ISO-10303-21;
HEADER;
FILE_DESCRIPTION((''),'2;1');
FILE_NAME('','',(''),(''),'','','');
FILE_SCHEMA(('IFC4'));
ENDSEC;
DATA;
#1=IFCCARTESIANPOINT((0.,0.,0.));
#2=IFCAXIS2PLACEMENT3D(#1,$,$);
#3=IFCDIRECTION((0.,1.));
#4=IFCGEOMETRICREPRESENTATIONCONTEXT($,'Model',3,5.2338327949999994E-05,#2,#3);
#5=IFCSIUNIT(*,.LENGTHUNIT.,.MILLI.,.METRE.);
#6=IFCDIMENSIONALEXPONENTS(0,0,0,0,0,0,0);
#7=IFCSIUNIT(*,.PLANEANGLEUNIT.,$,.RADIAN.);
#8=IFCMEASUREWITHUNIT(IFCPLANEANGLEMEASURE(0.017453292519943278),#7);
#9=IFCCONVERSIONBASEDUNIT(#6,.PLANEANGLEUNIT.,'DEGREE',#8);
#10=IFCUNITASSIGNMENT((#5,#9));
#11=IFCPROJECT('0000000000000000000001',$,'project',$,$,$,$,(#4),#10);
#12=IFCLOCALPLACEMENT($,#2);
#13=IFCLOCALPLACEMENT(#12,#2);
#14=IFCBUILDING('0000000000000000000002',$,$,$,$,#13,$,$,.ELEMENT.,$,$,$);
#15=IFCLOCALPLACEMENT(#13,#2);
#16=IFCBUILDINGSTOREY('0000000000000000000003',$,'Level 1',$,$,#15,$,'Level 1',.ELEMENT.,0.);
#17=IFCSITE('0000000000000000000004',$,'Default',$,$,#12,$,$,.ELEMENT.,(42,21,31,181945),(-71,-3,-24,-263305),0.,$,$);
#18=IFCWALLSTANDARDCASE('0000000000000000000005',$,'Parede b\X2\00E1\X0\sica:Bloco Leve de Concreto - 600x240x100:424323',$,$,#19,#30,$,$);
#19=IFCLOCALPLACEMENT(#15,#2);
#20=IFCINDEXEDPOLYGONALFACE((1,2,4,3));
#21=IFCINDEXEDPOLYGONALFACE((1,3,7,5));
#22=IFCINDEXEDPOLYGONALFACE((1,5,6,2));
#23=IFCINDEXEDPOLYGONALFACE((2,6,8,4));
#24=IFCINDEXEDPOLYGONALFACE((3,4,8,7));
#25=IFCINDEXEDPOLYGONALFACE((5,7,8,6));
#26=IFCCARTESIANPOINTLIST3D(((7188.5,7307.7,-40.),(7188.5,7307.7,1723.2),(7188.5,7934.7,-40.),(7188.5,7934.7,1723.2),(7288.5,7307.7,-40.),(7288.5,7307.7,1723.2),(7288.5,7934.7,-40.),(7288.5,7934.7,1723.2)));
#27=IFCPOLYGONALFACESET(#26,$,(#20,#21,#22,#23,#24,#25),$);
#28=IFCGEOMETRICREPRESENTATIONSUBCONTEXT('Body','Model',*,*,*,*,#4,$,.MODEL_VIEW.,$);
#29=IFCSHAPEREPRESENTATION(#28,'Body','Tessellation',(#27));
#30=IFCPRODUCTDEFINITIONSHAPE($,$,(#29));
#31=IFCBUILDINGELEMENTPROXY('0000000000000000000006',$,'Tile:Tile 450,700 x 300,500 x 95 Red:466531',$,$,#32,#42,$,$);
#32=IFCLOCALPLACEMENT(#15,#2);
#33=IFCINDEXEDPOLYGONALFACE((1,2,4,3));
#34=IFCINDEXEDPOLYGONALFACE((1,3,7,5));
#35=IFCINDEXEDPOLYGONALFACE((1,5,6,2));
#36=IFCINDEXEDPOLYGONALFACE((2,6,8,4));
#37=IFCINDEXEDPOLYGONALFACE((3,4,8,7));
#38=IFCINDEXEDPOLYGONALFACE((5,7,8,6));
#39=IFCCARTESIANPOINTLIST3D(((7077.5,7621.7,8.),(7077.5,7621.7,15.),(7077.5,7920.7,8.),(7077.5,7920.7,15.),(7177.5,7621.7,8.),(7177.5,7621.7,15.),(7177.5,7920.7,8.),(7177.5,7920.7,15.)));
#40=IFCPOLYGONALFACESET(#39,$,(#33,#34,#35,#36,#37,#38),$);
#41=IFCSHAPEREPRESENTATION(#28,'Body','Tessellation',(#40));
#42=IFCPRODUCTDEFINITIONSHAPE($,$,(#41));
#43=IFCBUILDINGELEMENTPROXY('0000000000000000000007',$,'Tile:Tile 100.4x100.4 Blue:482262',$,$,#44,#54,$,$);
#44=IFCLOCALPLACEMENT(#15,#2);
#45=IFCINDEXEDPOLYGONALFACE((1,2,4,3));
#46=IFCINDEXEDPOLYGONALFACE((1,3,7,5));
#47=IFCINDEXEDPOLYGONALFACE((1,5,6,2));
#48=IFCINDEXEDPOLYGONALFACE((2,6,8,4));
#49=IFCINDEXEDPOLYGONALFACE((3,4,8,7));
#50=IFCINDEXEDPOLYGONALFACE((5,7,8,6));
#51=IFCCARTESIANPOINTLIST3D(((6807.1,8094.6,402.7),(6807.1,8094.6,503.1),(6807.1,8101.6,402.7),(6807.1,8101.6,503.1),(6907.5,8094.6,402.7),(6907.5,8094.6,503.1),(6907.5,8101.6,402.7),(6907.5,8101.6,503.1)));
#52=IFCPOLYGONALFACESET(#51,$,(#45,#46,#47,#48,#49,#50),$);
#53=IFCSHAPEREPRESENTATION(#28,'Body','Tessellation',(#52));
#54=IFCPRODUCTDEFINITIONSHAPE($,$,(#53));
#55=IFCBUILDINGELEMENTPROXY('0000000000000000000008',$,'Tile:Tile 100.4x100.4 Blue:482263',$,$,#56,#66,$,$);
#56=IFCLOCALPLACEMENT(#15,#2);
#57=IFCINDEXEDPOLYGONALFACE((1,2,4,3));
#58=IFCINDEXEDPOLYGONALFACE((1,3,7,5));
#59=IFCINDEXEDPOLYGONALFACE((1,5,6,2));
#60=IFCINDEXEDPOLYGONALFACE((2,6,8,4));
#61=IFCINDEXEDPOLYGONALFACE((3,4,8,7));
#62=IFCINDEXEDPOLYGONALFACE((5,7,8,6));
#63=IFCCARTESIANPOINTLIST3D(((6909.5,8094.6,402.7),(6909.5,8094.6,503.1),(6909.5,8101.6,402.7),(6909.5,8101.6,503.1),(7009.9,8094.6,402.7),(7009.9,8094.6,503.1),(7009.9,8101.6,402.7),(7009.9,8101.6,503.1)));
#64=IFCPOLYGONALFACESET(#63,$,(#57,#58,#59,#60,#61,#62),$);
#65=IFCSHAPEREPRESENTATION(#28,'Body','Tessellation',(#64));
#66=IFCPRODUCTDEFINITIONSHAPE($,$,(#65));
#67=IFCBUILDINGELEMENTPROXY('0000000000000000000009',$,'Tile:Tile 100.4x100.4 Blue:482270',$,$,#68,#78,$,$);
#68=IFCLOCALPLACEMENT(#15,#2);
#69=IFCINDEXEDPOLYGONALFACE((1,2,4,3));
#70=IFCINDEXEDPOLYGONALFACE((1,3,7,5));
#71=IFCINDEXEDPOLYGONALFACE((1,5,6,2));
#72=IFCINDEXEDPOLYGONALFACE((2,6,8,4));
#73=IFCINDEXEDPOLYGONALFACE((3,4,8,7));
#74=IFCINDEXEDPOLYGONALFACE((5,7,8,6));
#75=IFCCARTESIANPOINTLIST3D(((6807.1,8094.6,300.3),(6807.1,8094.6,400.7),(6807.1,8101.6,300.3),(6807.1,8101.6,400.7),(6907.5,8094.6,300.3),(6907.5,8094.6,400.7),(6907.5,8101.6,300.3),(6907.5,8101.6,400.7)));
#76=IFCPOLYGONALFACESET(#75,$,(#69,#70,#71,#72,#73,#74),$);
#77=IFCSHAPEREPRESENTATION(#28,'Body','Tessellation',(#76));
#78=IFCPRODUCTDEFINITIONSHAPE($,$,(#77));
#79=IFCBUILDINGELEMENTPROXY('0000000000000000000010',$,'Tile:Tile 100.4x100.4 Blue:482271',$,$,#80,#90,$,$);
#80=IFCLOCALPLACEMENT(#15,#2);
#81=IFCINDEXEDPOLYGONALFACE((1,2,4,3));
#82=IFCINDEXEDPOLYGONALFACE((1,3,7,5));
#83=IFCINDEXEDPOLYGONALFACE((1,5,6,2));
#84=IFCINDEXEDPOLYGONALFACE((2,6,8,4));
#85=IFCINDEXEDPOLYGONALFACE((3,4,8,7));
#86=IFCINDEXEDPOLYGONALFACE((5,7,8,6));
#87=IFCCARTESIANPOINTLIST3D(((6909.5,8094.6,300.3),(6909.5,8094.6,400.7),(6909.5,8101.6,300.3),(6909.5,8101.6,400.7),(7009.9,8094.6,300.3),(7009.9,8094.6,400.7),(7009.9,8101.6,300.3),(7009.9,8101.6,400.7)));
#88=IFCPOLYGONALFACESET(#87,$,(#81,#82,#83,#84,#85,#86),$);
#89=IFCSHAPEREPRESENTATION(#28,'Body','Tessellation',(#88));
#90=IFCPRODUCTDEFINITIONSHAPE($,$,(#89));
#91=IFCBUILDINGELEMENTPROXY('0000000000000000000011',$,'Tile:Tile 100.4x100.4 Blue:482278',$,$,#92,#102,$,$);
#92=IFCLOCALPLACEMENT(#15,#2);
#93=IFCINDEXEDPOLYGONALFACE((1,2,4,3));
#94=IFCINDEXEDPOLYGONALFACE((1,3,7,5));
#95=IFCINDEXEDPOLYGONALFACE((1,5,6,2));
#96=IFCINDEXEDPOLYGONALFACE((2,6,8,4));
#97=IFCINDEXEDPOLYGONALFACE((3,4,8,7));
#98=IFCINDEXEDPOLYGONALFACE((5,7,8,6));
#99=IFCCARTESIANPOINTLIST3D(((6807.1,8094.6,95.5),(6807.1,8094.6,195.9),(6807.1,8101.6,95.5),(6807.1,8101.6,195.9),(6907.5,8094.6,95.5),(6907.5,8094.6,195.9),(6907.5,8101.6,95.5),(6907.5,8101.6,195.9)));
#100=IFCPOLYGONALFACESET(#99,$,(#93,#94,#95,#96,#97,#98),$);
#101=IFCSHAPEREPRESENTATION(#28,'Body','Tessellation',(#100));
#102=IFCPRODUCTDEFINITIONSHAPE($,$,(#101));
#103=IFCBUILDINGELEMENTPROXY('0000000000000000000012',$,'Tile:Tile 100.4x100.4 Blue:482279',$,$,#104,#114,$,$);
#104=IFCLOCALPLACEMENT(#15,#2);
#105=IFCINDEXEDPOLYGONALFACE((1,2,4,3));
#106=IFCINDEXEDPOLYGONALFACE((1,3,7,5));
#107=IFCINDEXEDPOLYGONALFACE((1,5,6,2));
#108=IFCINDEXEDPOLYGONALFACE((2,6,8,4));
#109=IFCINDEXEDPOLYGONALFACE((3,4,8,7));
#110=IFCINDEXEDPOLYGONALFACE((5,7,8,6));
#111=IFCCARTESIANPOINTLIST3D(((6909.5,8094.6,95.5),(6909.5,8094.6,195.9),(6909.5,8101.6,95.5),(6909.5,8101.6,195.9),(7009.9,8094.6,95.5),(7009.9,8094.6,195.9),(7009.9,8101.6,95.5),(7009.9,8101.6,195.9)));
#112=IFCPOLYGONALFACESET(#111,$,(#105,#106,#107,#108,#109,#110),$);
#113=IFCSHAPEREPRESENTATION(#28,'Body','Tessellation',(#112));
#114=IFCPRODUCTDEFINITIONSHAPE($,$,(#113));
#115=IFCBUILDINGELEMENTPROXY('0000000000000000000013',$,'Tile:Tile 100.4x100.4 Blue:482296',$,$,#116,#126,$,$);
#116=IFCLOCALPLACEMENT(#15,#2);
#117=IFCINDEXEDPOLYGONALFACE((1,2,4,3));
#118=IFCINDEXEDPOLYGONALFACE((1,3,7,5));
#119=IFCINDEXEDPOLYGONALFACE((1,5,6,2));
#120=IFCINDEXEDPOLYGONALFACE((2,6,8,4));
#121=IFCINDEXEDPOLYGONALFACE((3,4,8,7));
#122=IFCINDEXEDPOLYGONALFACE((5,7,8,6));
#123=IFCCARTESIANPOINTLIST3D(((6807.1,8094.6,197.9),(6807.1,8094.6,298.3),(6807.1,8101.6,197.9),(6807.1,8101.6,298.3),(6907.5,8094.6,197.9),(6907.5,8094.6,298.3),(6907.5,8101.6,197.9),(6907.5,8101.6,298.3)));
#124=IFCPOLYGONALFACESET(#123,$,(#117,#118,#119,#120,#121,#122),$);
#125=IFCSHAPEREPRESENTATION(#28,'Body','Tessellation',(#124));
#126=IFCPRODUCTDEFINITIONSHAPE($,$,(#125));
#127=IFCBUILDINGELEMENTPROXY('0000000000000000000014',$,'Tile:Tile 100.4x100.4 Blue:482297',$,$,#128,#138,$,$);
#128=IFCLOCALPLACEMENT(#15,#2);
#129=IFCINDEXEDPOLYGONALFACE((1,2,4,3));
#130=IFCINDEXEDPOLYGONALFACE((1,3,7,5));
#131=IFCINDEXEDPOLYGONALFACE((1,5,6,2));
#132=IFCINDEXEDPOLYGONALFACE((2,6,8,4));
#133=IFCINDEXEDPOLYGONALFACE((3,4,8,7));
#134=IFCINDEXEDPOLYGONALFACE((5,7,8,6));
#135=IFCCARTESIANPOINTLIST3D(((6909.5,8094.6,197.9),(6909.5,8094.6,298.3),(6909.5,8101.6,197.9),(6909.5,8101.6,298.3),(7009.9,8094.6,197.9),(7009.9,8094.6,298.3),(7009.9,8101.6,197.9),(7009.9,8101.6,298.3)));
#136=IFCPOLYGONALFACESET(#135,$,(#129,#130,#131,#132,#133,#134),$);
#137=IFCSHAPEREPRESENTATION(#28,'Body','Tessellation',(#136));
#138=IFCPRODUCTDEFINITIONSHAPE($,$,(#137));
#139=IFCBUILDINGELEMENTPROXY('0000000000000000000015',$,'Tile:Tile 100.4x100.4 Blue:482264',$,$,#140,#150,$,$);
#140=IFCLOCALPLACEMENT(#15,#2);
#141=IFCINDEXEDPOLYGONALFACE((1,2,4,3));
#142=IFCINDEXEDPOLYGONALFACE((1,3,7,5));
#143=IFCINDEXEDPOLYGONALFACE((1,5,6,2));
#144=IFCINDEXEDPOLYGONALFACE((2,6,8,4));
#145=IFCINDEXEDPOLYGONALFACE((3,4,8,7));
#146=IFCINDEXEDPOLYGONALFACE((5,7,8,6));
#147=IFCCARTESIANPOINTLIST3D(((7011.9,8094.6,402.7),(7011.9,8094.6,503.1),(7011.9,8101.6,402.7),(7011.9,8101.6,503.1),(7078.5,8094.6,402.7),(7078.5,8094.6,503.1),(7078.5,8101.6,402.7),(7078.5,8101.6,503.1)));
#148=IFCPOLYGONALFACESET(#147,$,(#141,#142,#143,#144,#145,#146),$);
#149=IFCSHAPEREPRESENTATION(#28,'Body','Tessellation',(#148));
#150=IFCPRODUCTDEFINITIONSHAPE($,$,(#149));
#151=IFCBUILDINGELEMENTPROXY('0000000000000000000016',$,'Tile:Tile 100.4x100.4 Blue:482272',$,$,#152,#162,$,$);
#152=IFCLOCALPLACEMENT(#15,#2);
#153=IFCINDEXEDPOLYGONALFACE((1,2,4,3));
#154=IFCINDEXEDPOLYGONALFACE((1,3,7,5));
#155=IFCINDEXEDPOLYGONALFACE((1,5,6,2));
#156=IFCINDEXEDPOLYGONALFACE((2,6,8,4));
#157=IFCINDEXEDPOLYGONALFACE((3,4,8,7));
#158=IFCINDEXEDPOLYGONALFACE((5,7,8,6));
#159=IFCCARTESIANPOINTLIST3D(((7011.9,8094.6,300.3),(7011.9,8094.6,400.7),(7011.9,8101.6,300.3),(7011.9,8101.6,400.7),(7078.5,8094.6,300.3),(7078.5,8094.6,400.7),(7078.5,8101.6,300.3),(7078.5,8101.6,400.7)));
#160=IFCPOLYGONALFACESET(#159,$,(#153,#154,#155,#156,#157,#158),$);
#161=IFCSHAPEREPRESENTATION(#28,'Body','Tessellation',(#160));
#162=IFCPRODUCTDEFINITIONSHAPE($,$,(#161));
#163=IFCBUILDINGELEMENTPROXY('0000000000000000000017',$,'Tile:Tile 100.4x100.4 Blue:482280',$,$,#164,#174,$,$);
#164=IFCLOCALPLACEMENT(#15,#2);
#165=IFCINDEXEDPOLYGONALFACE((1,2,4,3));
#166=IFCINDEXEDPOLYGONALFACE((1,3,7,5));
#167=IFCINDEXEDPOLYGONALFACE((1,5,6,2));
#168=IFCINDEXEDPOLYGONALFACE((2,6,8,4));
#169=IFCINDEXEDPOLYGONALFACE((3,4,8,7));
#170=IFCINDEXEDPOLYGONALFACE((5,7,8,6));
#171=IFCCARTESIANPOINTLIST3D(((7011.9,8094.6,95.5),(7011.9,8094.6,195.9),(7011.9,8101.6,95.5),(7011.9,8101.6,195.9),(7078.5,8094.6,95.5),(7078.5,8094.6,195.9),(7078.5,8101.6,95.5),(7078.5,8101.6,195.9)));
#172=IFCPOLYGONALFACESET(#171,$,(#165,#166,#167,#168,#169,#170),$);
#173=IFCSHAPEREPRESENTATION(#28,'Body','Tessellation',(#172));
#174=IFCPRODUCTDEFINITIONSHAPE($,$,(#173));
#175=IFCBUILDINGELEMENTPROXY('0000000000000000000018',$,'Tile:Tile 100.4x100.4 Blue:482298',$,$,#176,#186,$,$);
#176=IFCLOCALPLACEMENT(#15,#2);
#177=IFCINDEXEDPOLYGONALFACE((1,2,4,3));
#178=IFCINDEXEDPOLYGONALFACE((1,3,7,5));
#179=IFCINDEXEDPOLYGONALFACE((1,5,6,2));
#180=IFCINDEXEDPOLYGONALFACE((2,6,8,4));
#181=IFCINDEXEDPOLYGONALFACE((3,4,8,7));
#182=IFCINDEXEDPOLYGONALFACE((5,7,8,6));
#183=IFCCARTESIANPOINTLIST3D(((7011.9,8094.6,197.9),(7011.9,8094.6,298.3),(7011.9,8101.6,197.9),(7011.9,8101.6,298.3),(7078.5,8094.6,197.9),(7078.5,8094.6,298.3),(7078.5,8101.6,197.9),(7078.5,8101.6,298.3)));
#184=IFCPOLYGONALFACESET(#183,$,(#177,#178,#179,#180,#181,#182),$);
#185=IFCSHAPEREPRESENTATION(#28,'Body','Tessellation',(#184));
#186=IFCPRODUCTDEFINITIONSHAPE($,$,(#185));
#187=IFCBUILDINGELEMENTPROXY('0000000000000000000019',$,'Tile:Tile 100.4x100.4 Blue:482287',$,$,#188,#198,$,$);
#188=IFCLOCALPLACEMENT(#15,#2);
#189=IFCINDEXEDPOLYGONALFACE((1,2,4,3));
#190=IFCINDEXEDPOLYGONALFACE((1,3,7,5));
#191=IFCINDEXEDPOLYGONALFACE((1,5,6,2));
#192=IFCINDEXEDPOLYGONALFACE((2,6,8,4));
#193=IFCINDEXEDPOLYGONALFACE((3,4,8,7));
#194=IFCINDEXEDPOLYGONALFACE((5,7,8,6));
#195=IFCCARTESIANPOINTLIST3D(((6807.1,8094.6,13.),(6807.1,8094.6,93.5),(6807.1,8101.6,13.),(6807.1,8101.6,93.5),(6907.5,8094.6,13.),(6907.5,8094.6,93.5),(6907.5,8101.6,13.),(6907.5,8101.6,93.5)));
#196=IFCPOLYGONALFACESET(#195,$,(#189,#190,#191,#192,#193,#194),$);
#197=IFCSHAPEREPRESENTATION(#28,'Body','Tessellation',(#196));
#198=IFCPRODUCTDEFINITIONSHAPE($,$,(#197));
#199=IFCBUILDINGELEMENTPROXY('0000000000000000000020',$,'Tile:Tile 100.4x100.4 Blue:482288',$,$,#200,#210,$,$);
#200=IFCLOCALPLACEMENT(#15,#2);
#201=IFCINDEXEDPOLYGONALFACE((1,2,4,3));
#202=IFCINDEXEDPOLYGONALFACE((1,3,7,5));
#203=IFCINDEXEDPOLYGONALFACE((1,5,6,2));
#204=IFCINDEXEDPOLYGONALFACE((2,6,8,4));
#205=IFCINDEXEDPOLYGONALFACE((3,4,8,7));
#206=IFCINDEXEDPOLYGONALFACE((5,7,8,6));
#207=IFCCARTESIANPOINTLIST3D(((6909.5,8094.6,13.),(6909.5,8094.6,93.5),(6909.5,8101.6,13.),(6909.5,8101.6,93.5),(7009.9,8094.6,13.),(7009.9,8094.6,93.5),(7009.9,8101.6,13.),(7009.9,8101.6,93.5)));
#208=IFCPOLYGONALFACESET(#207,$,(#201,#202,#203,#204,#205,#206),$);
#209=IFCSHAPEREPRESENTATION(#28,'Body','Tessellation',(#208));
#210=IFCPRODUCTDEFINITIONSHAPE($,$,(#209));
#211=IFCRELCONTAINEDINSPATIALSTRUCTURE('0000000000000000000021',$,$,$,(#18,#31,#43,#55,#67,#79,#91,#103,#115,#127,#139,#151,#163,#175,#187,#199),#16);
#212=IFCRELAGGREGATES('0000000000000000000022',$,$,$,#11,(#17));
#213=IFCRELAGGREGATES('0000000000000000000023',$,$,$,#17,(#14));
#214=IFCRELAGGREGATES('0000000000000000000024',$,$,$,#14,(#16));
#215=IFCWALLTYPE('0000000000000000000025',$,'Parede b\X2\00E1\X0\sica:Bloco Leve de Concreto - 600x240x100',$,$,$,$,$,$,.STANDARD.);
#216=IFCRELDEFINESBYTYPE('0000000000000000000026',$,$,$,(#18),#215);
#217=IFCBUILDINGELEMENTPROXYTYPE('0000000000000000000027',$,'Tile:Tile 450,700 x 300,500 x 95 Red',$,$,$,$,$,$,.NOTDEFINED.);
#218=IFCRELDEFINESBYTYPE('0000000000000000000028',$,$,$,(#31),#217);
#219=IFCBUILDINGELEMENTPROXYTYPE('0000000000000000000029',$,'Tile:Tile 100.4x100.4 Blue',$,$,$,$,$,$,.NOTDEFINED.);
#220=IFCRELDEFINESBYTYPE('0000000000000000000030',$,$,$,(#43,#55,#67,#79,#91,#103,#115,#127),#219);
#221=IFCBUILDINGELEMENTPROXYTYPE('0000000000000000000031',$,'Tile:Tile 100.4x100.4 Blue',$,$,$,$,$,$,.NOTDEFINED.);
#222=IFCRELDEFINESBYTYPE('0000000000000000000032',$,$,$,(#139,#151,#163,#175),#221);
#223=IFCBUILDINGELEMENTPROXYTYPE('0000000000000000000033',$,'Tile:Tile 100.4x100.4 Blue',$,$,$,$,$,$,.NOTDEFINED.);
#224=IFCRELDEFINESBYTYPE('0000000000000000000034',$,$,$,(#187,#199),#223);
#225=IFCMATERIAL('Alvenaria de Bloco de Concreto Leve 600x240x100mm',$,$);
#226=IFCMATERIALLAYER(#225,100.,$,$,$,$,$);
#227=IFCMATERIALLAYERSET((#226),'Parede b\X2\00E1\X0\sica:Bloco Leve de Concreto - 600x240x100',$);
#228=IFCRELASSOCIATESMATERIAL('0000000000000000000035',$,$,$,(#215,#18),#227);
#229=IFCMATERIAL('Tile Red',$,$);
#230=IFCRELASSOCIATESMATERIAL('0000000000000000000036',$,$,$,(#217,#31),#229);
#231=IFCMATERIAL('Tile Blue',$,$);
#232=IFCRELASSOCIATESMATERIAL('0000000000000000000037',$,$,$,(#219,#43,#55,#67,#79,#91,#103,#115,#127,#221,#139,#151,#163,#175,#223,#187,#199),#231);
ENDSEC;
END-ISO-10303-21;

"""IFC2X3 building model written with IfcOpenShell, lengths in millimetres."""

from ifc_helpers import new_model, entity, si_unit, converted_unit, direction, frame, frame_2d, origin, origin_2d_with_axis, place, context, subcontext, project, spatial, rectangle, extrude, source, transform, mapped, material, layer, layer_set, layer_usage, type_object, type_shapes, element, save


model = new_model("IFC2X3")

# Units and contexts
model_context = context("Model", 3, precision=5.2338327949999994e-05, world=origin(), true_north=direction((0.0, 1.0)))
body_context = subcontext(model_context, "Body", "Model", "MODEL_VIEW")
ifc_project = project(units=[si_unit("LENGTHUNIT", "METRE", prefix="MILLI"), converted_unit("PLANEANGLEUNIT", "DEGREE", entity("IfcPlaneAngleMeasure", 0.017453292519943278), si_unit("PLANEANGLEUNIT", "RADIAN"), dimensions=[0, 0, 0, 0, 0, 0, 0])], contexts=[model_context])

# Site, building, storey
site_placement = place(None, origin())
site = spatial("IfcSite", under=ifc_project, at=site_placement, Name="Default", CompositionType="ELEMENT", RefLatitude=(42, 21, 31, 181945), RefLongitude=(-71, -3, -24, -263305), RefElevation=0.0)
building_placement = place(site_placement, origin())
building = spatial("IfcBuilding", under=site, at=building_placement, CompositionType="ELEMENT")
storey_placement = place(building_placement, origin())
storey = spatial("IfcBuildingStorey", under=building, at=storey_placement, Name="Level 1", LongName="Level 1", CompositionType="ELEMENT", Elevation=0.0)

# Wall
ifc_material_1 = material(Name="Alvenaria de Bloco de Concreto Leve 600x240x100mm")
ifc_layer = layer(ifc_material_1, 100.0)
ifc_layer_set = layer_set([ifc_layer], Name="Parede básica:Bloco Leve de Concreto - 600x240x100")
ifc_layer_usage = layer_usage(ifc_layer_set, "AXIS2", "NEGATIVE", 50.0)
wall_type = type_object("IfcWallType", Name="Parede básica:Bloco Leve de Concreto - 600x240x100", PredefinedType="STANDARD", material=ifc_layer_set)
wall_placement = place(storey_placement, frame((7238.5, 7934.7, -40.0), z_axis=(0.0, 0.0, 1.0), x_axis=(0.0, -1.0, 0.0)))
element("IfcWallStandardCase", 1, at=wall_placement, inside=storey, type_object=wall_type, material=ifc_layer_usage, Name="Parede básica:Bloco Leve de Concreto - 600x240x100:424323", context=body_context, shape_type="SweptSolid", body=[
    extrude(rectangle(XDim=627.0, YDim=100.0, at=frame_2d((313.5, 0.0), x_axis=(-1.0, 0.0))), origin(), (0.0, 0.0, 1.0), 1763.2),
])

# Building element proxies
ifc_material_2 = material(Name="Tile Red")
building_element_proxy_type_1 = type_object("IfcBuildingElementProxyType", Name="Tile:Tile 450,700 x 300,500 x 95 Red", PredefinedType="NOTDEFINED", material=ifc_material_2)
shared_shape_1 = source(origin(), body_context, "Body", "SweptSolid", [
    extrude(rectangle(XDim=100.0, YDim=299.0, at=origin_2d_with_axis()), frame((-50.0, -149.5, 0.0), z_axis=(0.0, 0.0, 1.0), x_axis=(-1.0, 0.0, 0.0)), (0.0, 0.0, 1.0), 7.0),
])
type_shapes(building_element_proxy_type_1, [shared_shape_1])
proxy_1_placement = place(storey_placement, frame((7177.5, 7920.7, 8.0)))
element("IfcBuildingElementProxy", 2, at=proxy_1_placement, inside=storey, type_object=building_element_proxy_type_1, material=ifc_material_2, Name="Tile:Tile 450,700 x 300,500 x 95 Red:466531", context=body_context, shape_type="MappedRepresentation", body=[
    mapped(shared_shape_1, transform((0.0, 0.0, 0.0), scale=1.0)),
])
ifc_material_3 = material(Name="Tile Blue")
building_element_proxy_type_2 = type_object("IfcBuildingElementProxyType", Name="Tile:Tile 100.4x100.4 Blue", PredefinedType="NOTDEFINED", material=ifc_material_3)
shared_shape_2 = source(origin(), body_context, "Body", "SweptSolid", [
    extrude(rectangle(XDim=100.4, YDim=100.4, at=origin_2d_with_axis()), frame((-50.2, -50.2, 0.0), z_axis=(0.0, 0.0, 1.0), x_axis=(0.0, -1.0, 0.0)), (0.0, 0.0, 1.0), 7.0),
])
type_shapes(building_element_proxy_type_2, [shared_shape_2])
for number, where, z_axis, x_axis, name in (
    (3, (6807.1, 8101.6, 402.7), (0.0, -1.0, 0.0), (-1.0, 0.0, 0.0), "Tile:Tile 100.4x100.4 Blue:482262"),
    (4, (6909.5, 8101.6, 402.7), (0.0, -1.0, 0.0), (-1.0, 0.0, 0.0), "Tile:Tile 100.4x100.4 Blue:482263"),
    (5, (6807.1, 8101.6, 300.3), (0.0, -1.0, 0.0), (-1.0, 0.0, 0.0), "Tile:Tile 100.4x100.4 Blue:482270"),
    (6, (6909.5, 8101.6, 300.3), (0.0, -1.0, 0.0), (-1.0, 0.0, 0.0), "Tile:Tile 100.4x100.4 Blue:482271"),
    (7, (6807.1, 8101.6, 95.5), (0.0, -1.0, 0.0), (-1.0, 0.0, 0.0), "Tile:Tile 100.4x100.4 Blue:482278"),
    (8, (6909.5, 8101.6, 95.5), (0.0, -1.0, 0.0), (-1.0, 0.0, 0.0), "Tile:Tile 100.4x100.4 Blue:482279"),
    (9, (6807.1, 8101.6, 197.9), (0.0, -1.0, 0.0), (-1.0, 0.0, 0.0), "Tile:Tile 100.4x100.4 Blue:482296"),
    (10, (6909.5, 8101.6, 197.9), (0.0, -1.0, 0.0), (-1.0, 0.0, 0.0), "Tile:Tile 100.4x100.4 Blue:482297"),
):
    element("IfcBuildingElementProxy", number, at=place(storey_placement, frame(where, z_axis=z_axis, x_axis=x_axis)), inside=storey, type_object=building_element_proxy_type_2, material=ifc_material_3, Name=name, context=body_context, shape_type="MappedRepresentation", body=[
        mapped(shared_shape_2, transform((0.0, 0.0, 0.0), scale=1.0)),
    ])
building_element_proxy_type_3 = type_object("IfcBuildingElementProxyType", Name="Tile:Tile 100.4x100.4 Blue", PredefinedType="NOTDEFINED", material=ifc_material_3)
shared_shape_3 = source(origin(), body_context, "Body", "SweptSolid", [
    extrude(rectangle(XDim=66.6, YDim=100.4, at=origin_2d_with_axis()), frame((-33.3, -50.2, 0.0), z_axis=(0.0, 0.0, 1.0), x_axis=(-1.0, 0.0, 0.0)), (0.0, 0.0, 1.0), 7.0),
])
type_shapes(building_element_proxy_type_3, [shared_shape_3])
for number, where, z_axis, x_axis, name in (
    (11, (7011.9, 8101.6, 402.7), (0.0, -1.0, 0.0), (-1.0, 0.0, 0.0), "Tile:Tile 100.4x100.4 Blue:482264"),
    (12, (7011.9, 8101.6, 300.3), (0.0, -1.0, 0.0), (-1.0, 0.0, 0.0), "Tile:Tile 100.4x100.4 Blue:482272"),
    (13, (7011.9, 8101.6, 95.5), (0.0, -1.0, 0.0), (-1.0, 0.0, 0.0), "Tile:Tile 100.4x100.4 Blue:482280"),
    (14, (7011.9, 8101.6, 197.9), (0.0, -1.0, 0.0), (-1.0, 0.0, 0.0), "Tile:Tile 100.4x100.4 Blue:482298"),
):
    element("IfcBuildingElementProxy", number, at=place(storey_placement, frame(where, z_axis=z_axis, x_axis=x_axis)), inside=storey, type_object=building_element_proxy_type_3, material=ifc_material_3, Name=name, context=body_context, shape_type="MappedRepresentation", body=[
        mapped(shared_shape_3, transform((0.0, 0.0, 0.0), scale=1.0)),
    ])
building_element_proxy_type_4 = type_object("IfcBuildingElementProxyType", Name="Tile:Tile 100.4x100.4 Blue", PredefinedType="NOTDEFINED", material=ifc_material_3)
shared_shape_4 = source(origin(), body_context, "Body", "SweptSolid", [
    extrude(rectangle(XDim=80.5, YDim=100.4, at=origin_2d_with_axis()), frame((-50.2, -40.3, 0.0), z_axis=(0.0, 0.0, 1.0), x_axis=(0.0, -1.0, 0.0)), (0.0, 0.0, 1.0), 7.0),
])
type_shapes(building_element_proxy_type_4, [shared_shape_4])
for number, where, z_axis, x_axis, name in (
    (15, (6807.1, 8101.6, 13.0), (0.0, -1.0, 0.0), (-1.0, 0.0, 0.0), "Tile:Tile 100.4x100.4 Blue:482287"),
    (16, (6909.5, 8101.6, 13.0), (0.0, -1.0, 0.0), (-1.0, 0.0, 0.0), "Tile:Tile 100.4x100.4 Blue:482288"),
):
    element("IfcBuildingElementProxy", number, at=place(storey_placement, frame(where, z_axis=z_axis, x_axis=x_axis)), inside=storey, type_object=building_element_proxy_type_4, material=ifc_material_3, Name=name, context=body_context, shape_type="MappedRepresentation", body=[
        mapped(shared_shape_4, transform((0.0, 0.0, 0.0), scale=1.0)),
    ])

save(model, "model.ifc")
